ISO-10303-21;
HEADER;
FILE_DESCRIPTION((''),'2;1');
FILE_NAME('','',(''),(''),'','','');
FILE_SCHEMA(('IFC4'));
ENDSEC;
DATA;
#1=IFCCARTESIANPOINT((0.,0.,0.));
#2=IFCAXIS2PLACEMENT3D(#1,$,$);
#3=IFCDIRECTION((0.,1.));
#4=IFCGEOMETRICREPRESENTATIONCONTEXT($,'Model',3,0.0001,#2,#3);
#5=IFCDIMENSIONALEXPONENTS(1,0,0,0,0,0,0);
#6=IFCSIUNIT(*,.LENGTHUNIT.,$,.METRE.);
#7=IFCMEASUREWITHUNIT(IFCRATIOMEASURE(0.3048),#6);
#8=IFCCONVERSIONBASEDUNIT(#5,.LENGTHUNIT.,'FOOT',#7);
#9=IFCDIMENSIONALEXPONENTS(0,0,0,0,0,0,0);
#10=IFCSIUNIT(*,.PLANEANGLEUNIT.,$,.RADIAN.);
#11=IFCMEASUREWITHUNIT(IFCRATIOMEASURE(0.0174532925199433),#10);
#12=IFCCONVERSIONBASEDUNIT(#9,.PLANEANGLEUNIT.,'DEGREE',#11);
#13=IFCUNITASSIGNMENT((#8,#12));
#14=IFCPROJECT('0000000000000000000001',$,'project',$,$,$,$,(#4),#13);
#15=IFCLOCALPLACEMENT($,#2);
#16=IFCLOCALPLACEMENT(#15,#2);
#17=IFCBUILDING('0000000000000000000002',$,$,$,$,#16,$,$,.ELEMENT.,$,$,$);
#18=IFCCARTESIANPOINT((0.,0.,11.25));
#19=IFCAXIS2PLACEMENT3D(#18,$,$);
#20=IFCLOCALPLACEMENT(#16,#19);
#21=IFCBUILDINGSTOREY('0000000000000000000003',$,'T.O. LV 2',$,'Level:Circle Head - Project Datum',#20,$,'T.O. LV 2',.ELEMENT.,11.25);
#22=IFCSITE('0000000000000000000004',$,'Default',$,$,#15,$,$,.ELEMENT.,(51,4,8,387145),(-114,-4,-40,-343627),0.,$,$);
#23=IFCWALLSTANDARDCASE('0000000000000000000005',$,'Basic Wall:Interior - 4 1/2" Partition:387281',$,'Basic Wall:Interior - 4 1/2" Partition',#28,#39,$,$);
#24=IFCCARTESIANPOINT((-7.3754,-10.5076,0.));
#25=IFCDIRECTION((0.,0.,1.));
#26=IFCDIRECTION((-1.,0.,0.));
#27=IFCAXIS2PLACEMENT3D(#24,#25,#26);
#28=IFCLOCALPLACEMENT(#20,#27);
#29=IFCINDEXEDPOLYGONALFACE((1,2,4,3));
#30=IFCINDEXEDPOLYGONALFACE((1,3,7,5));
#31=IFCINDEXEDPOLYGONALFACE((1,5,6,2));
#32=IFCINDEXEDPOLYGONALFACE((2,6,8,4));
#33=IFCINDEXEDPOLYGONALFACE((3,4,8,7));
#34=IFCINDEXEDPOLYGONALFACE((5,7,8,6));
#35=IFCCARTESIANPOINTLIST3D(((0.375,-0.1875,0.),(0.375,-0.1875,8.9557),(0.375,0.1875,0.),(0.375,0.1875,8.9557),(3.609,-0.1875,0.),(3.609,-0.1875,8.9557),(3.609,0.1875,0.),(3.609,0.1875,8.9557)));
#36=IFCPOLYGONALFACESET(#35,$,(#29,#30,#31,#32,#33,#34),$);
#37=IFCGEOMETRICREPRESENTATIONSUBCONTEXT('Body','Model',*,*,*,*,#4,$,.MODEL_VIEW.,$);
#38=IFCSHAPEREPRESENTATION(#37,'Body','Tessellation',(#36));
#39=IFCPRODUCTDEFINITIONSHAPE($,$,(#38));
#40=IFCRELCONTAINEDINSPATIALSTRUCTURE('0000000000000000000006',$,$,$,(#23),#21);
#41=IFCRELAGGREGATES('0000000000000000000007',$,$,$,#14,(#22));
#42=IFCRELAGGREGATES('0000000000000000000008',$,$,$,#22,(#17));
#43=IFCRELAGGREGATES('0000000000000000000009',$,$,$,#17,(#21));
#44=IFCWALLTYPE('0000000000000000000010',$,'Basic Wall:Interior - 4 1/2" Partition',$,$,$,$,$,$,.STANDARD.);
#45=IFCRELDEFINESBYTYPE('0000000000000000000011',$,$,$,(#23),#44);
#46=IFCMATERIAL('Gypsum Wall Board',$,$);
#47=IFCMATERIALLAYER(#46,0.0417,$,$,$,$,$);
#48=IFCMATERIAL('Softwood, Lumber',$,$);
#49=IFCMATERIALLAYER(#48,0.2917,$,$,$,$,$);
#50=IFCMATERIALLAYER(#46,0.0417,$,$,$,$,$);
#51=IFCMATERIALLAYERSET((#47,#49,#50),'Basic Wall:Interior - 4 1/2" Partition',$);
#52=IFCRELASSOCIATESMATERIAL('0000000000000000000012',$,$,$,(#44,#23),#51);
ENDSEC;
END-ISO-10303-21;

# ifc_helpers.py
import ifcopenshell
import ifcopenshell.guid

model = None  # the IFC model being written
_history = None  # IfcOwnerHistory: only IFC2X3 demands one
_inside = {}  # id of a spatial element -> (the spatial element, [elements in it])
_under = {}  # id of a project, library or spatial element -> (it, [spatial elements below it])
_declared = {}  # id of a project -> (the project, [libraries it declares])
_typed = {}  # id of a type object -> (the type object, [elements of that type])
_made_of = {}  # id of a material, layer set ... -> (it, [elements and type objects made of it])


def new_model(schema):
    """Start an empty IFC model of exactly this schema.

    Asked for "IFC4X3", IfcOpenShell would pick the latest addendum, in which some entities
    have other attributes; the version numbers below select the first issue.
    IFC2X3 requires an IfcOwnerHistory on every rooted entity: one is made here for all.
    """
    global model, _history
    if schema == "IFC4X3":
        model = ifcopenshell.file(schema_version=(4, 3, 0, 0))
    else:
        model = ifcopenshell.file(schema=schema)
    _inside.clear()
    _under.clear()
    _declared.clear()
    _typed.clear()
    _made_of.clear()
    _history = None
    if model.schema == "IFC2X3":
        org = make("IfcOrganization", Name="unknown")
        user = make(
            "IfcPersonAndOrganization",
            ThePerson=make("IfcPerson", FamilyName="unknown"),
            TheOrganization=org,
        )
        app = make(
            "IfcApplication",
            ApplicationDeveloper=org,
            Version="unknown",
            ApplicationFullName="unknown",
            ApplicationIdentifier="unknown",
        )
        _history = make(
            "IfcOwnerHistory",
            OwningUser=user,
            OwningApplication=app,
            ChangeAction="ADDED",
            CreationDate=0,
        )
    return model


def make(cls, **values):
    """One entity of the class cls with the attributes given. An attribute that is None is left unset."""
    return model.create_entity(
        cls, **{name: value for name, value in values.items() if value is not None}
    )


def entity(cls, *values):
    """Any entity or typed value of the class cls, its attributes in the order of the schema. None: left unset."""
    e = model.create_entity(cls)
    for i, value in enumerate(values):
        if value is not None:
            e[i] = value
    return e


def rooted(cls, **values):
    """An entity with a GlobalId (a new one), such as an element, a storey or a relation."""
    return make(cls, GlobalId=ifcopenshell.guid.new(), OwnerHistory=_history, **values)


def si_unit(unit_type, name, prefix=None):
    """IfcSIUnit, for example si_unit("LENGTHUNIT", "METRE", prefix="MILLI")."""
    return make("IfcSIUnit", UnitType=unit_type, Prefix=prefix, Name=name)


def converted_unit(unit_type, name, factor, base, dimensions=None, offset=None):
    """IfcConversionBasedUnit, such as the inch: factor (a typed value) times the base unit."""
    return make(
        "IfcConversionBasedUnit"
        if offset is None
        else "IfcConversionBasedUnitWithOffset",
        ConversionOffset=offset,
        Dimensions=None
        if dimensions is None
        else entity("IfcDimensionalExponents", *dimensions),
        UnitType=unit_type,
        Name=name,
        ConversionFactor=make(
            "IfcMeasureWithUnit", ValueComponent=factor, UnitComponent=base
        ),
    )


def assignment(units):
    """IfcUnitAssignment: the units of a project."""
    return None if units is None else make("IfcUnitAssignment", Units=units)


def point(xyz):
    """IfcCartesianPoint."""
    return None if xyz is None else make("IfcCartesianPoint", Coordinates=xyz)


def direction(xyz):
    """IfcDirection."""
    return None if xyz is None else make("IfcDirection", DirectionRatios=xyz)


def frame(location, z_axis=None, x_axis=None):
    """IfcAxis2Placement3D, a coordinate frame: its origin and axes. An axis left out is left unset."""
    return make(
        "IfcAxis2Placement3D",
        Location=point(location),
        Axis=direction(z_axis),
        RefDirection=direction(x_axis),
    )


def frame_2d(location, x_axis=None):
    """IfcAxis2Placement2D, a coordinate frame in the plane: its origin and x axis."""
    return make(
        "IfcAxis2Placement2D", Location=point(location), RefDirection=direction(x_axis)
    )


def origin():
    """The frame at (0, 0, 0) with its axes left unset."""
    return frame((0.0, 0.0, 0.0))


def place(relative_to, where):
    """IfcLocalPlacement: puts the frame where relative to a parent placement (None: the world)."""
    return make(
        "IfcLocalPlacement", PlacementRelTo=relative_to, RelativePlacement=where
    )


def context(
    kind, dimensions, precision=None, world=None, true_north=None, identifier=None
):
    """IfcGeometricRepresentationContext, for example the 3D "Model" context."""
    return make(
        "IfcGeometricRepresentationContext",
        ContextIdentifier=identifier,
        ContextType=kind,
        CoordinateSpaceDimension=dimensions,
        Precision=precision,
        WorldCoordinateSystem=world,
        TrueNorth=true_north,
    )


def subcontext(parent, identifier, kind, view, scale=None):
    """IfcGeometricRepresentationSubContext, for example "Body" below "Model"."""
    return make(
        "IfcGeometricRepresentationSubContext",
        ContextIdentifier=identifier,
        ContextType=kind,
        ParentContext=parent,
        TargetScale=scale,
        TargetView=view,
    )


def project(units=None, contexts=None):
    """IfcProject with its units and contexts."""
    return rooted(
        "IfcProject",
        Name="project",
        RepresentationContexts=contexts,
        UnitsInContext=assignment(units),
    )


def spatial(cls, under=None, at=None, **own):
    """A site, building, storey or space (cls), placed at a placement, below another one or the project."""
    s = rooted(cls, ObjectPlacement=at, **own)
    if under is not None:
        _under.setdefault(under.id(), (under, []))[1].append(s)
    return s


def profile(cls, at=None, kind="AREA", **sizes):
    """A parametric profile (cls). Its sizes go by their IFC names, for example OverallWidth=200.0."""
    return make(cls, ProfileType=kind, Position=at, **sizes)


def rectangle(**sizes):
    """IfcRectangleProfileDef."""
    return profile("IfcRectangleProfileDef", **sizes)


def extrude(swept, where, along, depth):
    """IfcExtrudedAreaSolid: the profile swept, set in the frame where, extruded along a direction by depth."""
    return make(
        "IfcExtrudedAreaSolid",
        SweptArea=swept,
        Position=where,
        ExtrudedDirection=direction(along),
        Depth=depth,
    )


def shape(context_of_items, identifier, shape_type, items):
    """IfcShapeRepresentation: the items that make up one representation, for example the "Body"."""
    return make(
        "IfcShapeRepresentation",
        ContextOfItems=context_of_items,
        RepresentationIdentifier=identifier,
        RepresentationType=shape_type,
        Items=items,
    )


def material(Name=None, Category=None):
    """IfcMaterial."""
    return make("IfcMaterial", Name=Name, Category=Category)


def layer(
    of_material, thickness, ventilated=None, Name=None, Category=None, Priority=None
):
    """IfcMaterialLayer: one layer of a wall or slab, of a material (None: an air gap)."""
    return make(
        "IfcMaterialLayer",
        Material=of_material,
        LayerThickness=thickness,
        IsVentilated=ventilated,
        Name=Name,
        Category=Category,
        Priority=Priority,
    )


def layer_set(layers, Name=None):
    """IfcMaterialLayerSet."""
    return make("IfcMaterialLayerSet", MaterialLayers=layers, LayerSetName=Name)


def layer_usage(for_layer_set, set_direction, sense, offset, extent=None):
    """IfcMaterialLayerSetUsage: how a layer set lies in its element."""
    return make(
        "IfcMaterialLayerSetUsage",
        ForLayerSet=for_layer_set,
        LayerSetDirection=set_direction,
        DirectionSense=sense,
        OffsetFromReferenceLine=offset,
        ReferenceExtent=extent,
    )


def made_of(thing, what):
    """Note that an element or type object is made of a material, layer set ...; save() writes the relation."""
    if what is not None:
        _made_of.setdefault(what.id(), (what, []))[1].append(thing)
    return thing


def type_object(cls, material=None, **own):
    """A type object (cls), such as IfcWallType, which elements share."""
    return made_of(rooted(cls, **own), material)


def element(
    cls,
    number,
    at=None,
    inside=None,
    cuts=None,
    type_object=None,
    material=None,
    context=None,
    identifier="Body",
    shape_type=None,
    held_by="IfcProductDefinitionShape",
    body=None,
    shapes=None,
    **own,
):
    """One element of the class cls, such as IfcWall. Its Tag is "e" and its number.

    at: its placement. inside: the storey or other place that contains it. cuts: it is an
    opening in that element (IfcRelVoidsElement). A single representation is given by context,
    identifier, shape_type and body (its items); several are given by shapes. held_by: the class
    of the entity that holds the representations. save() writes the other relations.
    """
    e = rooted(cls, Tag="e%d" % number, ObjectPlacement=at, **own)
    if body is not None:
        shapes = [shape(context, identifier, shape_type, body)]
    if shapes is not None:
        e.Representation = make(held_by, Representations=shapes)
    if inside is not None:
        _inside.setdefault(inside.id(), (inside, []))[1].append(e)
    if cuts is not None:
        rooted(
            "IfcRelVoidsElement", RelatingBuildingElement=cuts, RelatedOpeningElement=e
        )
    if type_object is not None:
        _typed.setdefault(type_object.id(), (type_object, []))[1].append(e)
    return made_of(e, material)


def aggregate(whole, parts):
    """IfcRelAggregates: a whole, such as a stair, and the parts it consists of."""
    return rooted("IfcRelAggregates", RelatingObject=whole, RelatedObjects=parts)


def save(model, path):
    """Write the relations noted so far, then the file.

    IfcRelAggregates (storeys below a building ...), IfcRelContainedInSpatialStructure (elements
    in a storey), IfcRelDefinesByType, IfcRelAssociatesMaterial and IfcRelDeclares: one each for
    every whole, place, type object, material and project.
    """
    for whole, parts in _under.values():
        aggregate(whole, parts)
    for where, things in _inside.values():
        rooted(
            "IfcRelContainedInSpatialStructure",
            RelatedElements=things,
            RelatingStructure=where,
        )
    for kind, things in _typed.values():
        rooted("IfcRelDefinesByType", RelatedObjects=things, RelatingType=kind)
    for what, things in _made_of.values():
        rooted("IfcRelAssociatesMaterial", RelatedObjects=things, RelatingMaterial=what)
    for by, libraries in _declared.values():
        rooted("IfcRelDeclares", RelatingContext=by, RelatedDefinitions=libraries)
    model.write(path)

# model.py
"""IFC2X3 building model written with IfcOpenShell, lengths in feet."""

from ifc_helpers import new_model, entity, si_unit, converted_unit, direction, frame, frame_2d, origin, place, context, subcontext, project, spatial, rectangle, extrude, material, layer, layer_set, layer_usage, type_object, element, save


model = new_model("IFC2X3")

# Units and contexts
model_context = context("Model", 3, precision=0.0001, world=origin(), true_north=direction((0.0, 1.0)))
body_context = subcontext(model_context, "Body", "Model", "MODEL_VIEW")
ifc_project = project(units=[converted_unit("LENGTHUNIT", "FOOT", entity("IfcRatioMeasure", 0.3048), si_unit("LENGTHUNIT", "METRE"), dimensions=[1, 0, 0, 0, 0, 0, 0]), converted_unit("PLANEANGLEUNIT", "DEGREE", entity("IfcRatioMeasure", 0.0174532925199433), si_unit("PLANEANGLEUNIT", "RADIAN"), dimensions=[0, 0, 0, 0, 0, 0, 0])], contexts=[model_context])

# Site, building, storey
site_placement = place(None, origin())
site = spatial("IfcSite", under=ifc_project, at=site_placement, Name="Default", CompositionType="ELEMENT", RefLatitude=(51, 4, 8, 387145), RefLongitude=(-114, -4, -40, -343627), RefElevation=0.0)
building_placement = place(site_placement, origin())
building = spatial("IfcBuilding", under=site, at=building_placement, CompositionType="ELEMENT")
storey_placement = place(building_placement, frame((0.0, 0.0, 11.25)))
storey = spatial("IfcBuildingStorey", under=building, at=storey_placement, Name="T.O. LV 2", ObjectType="Level:Circle Head - Project Datum", LongName="T.O. LV 2", CompositionType="ELEMENT", Elevation=11.25)

# Wall
ifc_material_1 = material(Name="Gypsum Wall Board")
ifc_layer_1 = layer(ifc_material_1, 0.0417)
ifc_material_2 = material(Name="Softwood, Lumber")
ifc_layer_2 = layer(ifc_material_2, 0.2917)
ifc_layer_3 = layer(ifc_material_1, 0.0417)
ifc_layer_set_1 = layer_set([ifc_layer_1, ifc_layer_2, ifc_layer_3], Name="Basic Wall:Interior - 4 1/2\" Partition")
wall_type_1 = type_object("IfcWallType", Name="Basic Wall:Interior - 4 1/2\" Partition", PredefinedType="STANDARD", material=ifc_layer_set_1)
ifc_layer_usage_1 = layer_usage(ifc_layer_set_1, "AXIS2", "NEGATIVE", 0.1875)
wall_1_placement = place(storey_placement, frame((-7.3754, -10.5076, 0.0), z_axis=(0.0, 0.0, 1.0), x_axis=(-1.0, 0.0, 0.0)))
element("IfcWallStandardCase", 1, at=wall_1_placement, inside=storey, type_object=wall_type_1, material=ifc_layer_usage_1, Name="Basic Wall:Interior - 4 1/2\" Partition:387281", ObjectType="Basic Wall:Interior - 4 1/2\" Partition", context=body_context, shape_type="SweptSolid", body=[
    extrude(rectangle(XDim=3.234, YDim=0.375, at=frame_2d((1.992, 0.0), x_axis=(-1.0, 0.0))), origin(), (0.0, 0.0, 1.0), 8.9557),
])

save(model, "model.ifc")
